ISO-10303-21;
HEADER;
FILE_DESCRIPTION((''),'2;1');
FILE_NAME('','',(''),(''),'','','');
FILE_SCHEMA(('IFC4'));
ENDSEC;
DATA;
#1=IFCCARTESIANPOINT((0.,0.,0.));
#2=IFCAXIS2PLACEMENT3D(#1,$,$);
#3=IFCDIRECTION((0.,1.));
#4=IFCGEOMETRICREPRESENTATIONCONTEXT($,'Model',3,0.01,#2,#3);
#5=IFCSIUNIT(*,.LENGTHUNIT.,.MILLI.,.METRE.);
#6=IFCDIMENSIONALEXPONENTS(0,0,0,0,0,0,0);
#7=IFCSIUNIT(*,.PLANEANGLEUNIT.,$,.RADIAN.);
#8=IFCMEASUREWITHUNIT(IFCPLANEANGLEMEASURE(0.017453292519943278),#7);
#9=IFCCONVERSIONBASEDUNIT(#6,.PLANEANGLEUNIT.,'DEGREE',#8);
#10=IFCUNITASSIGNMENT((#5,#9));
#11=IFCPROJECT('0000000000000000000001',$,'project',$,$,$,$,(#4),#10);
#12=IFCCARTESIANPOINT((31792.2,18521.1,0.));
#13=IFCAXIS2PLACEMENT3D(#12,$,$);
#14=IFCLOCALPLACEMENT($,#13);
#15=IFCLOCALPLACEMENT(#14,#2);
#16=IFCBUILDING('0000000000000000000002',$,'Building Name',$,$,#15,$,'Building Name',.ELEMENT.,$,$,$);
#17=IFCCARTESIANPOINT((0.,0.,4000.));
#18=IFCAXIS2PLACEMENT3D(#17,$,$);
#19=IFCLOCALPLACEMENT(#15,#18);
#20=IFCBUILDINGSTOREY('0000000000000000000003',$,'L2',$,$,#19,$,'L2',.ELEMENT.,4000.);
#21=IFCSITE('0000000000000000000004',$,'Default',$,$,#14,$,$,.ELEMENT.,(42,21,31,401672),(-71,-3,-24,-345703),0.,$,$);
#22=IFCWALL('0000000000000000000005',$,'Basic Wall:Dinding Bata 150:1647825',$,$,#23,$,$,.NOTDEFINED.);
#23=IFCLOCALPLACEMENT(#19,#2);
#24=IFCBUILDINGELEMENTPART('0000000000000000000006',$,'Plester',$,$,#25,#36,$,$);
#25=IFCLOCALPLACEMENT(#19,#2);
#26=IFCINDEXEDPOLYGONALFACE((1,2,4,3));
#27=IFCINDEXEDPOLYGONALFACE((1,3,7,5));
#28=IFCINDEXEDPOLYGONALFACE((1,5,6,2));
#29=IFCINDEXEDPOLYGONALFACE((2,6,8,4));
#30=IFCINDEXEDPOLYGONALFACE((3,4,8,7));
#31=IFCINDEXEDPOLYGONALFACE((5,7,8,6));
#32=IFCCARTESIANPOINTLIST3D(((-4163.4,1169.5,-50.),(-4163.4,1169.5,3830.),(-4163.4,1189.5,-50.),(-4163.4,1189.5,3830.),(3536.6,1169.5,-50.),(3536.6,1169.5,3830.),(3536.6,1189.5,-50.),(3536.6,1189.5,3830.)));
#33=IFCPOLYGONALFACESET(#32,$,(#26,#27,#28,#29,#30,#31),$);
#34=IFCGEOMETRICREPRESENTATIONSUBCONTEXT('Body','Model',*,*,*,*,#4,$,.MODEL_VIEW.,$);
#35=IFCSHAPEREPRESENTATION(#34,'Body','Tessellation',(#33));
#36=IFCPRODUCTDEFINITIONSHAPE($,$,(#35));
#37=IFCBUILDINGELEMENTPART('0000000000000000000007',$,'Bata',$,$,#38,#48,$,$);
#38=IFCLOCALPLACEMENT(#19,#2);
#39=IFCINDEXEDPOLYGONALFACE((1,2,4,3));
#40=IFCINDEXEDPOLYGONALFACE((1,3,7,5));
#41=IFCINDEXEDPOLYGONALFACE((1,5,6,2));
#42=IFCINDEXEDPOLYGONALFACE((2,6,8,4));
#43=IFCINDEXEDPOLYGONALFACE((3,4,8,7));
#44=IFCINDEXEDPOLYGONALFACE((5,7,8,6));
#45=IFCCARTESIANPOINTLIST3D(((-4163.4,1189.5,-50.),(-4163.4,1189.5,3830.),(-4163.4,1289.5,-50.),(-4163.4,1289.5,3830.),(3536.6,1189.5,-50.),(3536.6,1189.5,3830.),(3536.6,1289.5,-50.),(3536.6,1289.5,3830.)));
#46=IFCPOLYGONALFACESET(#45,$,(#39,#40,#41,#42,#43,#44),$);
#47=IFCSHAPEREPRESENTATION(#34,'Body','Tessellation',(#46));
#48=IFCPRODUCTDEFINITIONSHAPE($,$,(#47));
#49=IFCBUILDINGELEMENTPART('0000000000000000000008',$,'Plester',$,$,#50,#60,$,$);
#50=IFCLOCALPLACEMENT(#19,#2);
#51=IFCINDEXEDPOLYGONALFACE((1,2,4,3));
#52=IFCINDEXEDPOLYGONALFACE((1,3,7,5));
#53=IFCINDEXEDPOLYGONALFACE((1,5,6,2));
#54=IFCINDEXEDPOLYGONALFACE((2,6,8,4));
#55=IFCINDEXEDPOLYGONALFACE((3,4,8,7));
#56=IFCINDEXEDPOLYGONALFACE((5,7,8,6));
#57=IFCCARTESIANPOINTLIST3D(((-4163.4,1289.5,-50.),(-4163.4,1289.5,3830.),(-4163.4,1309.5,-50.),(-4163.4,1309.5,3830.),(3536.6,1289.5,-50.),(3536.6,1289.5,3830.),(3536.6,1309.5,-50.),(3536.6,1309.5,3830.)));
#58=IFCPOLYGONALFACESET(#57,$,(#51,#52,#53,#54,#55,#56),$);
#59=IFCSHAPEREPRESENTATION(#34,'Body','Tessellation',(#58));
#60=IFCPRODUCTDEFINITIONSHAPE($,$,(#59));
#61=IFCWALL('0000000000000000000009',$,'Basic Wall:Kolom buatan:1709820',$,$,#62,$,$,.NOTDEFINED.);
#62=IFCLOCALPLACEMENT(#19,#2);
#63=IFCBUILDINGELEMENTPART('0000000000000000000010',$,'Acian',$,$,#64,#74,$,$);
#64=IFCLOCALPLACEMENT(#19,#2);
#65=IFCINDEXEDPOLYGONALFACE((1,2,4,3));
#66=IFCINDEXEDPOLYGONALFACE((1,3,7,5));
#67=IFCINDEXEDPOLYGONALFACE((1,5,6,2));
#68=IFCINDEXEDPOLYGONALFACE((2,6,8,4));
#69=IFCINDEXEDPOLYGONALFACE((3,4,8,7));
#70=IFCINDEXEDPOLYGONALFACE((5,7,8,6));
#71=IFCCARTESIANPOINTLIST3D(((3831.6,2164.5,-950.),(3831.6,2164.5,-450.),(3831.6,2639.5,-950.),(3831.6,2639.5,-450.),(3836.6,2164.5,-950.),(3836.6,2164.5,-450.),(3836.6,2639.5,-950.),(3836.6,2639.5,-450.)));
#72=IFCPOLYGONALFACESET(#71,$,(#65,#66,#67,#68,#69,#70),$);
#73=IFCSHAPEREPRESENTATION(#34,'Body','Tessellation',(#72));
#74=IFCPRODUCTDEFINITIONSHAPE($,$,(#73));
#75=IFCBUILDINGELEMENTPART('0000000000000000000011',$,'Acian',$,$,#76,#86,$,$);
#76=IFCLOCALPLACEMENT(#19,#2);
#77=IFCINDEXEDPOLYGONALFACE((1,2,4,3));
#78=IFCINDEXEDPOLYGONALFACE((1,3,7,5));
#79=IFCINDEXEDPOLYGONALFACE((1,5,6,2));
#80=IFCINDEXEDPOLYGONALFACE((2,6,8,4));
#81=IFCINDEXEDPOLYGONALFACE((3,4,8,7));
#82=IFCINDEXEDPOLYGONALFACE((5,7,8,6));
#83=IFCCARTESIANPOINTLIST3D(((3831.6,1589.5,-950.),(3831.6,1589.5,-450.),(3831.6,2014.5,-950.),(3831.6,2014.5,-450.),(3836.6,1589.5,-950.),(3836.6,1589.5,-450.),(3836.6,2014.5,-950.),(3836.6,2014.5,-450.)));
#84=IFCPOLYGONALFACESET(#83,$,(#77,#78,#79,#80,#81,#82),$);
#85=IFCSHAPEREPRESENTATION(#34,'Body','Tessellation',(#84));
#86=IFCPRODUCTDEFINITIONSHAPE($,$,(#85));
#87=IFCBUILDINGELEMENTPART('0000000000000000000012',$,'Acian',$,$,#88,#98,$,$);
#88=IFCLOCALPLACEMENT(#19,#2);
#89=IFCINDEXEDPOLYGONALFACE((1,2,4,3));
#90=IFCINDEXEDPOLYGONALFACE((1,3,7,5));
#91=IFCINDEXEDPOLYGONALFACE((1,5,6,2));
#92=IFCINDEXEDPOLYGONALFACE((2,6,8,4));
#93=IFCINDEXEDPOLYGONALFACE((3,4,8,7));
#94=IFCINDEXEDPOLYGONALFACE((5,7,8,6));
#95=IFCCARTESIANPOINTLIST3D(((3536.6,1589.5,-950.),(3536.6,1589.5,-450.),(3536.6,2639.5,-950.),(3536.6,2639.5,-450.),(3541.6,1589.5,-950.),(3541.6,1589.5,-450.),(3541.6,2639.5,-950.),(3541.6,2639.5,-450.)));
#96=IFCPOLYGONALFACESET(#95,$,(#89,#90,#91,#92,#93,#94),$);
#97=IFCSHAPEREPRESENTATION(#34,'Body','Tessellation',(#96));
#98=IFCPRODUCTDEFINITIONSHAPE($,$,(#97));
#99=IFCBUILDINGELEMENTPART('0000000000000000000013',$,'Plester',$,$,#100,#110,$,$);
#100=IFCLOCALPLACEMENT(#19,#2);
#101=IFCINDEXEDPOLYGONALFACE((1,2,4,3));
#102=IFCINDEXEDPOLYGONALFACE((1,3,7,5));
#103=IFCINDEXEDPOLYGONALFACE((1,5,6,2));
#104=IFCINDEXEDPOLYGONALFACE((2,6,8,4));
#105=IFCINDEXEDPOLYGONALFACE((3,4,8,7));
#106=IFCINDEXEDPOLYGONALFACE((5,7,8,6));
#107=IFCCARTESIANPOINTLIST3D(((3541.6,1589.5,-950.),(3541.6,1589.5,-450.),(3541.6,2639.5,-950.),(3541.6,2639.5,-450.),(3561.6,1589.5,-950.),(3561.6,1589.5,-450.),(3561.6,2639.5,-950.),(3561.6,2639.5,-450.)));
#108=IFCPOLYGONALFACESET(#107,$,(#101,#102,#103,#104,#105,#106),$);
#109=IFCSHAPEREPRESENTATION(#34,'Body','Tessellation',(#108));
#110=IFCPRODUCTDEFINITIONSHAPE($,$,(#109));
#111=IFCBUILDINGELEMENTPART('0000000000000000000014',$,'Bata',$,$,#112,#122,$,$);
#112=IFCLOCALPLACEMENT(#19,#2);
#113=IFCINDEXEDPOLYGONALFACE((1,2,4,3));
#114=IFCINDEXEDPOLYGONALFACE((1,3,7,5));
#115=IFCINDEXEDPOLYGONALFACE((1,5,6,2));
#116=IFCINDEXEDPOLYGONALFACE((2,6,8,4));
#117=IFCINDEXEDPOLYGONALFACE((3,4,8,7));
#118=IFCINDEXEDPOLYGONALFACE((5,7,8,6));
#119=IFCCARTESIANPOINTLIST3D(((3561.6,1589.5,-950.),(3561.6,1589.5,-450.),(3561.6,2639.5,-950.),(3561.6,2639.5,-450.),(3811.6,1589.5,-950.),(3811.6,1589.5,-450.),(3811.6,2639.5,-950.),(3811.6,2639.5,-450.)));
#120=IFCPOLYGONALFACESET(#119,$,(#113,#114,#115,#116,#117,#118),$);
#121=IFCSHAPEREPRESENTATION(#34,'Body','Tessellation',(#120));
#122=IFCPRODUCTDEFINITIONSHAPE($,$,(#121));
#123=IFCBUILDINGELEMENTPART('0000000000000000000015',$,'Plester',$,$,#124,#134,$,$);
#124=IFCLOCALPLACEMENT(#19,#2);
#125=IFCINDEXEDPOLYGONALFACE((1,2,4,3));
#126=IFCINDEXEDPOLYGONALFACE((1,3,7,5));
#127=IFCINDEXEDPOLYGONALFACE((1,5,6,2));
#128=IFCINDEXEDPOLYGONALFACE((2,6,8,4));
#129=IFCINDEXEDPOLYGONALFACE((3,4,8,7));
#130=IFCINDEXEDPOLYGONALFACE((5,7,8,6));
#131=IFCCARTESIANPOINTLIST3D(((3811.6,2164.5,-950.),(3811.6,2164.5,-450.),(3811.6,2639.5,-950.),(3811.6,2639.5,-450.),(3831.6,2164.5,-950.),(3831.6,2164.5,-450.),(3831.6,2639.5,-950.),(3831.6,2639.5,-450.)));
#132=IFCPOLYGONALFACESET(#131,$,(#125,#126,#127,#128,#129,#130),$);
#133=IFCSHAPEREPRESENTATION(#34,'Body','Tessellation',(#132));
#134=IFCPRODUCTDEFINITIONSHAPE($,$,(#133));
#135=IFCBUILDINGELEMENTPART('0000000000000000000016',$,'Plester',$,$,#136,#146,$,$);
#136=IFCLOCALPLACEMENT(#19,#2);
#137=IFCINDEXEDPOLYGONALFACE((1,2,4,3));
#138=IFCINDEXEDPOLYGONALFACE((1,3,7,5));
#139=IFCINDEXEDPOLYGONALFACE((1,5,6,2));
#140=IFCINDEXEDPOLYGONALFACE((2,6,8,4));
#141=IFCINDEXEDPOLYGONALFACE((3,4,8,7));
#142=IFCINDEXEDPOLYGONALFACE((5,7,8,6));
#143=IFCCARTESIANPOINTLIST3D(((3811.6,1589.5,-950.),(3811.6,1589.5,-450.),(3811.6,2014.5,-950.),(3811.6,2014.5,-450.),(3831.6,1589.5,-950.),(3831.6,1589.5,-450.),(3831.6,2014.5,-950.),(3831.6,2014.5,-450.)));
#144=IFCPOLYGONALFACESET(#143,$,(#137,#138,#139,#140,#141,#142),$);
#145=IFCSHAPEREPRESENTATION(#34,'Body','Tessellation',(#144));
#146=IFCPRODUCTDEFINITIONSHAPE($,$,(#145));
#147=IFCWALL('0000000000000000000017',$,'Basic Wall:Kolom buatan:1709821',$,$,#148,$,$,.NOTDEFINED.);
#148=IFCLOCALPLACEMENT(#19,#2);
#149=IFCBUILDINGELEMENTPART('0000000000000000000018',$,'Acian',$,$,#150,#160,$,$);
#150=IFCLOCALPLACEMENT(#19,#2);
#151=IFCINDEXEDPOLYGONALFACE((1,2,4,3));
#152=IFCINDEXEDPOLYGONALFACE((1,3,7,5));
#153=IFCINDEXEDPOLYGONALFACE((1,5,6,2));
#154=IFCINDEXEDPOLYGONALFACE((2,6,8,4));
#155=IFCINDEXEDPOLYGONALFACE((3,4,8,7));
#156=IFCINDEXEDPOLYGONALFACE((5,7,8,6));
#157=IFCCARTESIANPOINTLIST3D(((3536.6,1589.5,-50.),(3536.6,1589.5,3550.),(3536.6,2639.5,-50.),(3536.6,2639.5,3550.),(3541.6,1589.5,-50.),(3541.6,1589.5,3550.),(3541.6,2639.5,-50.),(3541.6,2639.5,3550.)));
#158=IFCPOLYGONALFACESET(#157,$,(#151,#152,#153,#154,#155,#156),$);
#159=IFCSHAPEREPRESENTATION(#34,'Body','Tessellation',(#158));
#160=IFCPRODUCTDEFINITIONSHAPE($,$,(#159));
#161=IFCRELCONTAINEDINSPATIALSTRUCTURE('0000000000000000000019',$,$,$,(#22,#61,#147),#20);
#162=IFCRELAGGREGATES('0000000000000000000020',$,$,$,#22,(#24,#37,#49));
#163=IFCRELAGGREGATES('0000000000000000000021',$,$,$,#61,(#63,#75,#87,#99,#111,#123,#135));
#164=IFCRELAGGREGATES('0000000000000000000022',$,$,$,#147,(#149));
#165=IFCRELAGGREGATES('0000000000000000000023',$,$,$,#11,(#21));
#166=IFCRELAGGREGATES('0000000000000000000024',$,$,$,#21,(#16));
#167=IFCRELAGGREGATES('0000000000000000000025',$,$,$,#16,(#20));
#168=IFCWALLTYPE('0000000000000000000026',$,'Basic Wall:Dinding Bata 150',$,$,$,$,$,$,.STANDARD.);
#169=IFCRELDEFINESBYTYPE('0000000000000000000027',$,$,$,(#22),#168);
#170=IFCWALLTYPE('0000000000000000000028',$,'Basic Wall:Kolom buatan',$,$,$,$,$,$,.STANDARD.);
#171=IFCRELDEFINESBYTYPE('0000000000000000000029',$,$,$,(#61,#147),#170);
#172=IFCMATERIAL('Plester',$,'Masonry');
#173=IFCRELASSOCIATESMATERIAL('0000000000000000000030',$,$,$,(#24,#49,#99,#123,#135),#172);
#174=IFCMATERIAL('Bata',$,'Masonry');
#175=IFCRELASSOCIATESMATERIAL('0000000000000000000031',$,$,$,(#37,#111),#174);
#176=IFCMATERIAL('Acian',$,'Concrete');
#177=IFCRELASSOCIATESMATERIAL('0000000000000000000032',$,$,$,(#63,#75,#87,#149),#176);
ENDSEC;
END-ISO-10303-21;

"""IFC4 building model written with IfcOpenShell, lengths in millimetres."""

from ifc_helpers import new_model, entity, si_unit, converted_unit, direction, frame, origin, place, context, subcontext, project, spatial, indexed_curve, outline, extrude, material, type_object, element, aggregate, save


model = new_model("IFC4")

# Units and contexts
model_context = context("Model", 3, precision=0.01, world=origin(), true_north=direction((0.0, 1.0)))
body_context = subcontext(model_context, "Body", "Model", "MODEL_VIEW")
ifc_project = project(units=[si_unit("LENGTHUNIT", "METRE", prefix="MILLI"), converted_unit("PLANEANGLEUNIT", "DEGREE", entity("IfcPlaneAngleMeasure", 0.017453292519943278), si_unit("PLANEANGLEUNIT", "RADIAN"), dimensions=[0, 0, 0, 0, 0, 0, 0])], contexts=[model_context])

# Site, building, storey
site_placement = place(None, frame((31792.2, 18521.1, 0.0)))
site = spatial("IfcSite", under=ifc_project, at=site_placement, Name="Default", CompositionType="ELEMENT", RefLatitude=(42, 21, 31, 401672), RefLongitude=(-71, -3, -24, -345703), RefElevation=0.0)
building_placement = place(site_placement, origin())
building = spatial("IfcBuilding", under=site, at=building_placement, Name="Building Name", LongName="Building Name", CompositionType="ELEMENT")
storey_placement = place(building_placement, frame((0.0, 0.0, 4000.0)))
storey = spatial("IfcBuildingStorey", under=building, at=storey_placement, Name="L2", LongName="L2", CompositionType="ELEMENT", Elevation=4000.0)

# Walls, building element parts
wall_type_1 = type_object("IfcWallType", Name="Basic Wall:Dinding Bata 150", PredefinedType="STANDARD")
ifc_material_1 = material(Name="Acian", Category="Concrete")
ifc_material_2 = material(Name="Plester", Category="Masonry")
ifc_material_3 = material(Name="Bata", Category="Masonry")
wall_1_placement = place(storey_placement, frame((3536.6, 1239.5, -50.0), z_axis=(0.0, 0.0, 1.0), x_axis=(-1.0, 0.0, 0.0)))
wall_1 = element("IfcWall", 1, at=wall_1_placement, inside=storey, type_object=wall_type_1, Name="Basic Wall:Dinding Bata 150:1647825", PredefinedType="NOTDEFINED")
building_element_part_1_placement = place(wall_1_placement, origin())
building_element_part_1 = element("IfcBuildingElementPart", 2, at=building_element_part_1_placement, material=ifc_material_2, Name="Plester", context=body_context, shape_type="SweptSolid", body=[
    extrude(outline(indexed_curve([(-10.0, -3850.0), (10.0, -3850.0), (10.0, 3850.0), (-10.0, 3850.0), (-10.0, -3850.0)], self_intersect=False)), frame((3850.0, 60.0, 0.0), z_axis=(0.0, 0.0, 1.0), x_axis=(0.0, 1.0, 0.0)), (0.0, 0.0, 1.0), 3880.0),
])
building_element_part_2_placement = place(wall_1_placement, origin())
building_element_part_2 = element("IfcBuildingElementPart", 3, at=building_element_part_2_placement, material=ifc_material_3, Name="Bata", context=body_context, shape_type="SweptSolid", body=[
    extrude(outline(indexed_curve([(-50.0, -3850.0), (50.0, -3850.0), (50.0, 3850.0), (-50.0, 3850.0), (-50.0, -3850.0)], self_intersect=False)), frame((3850.0, 0.0, 0.0), z_axis=(0.0, 0.0, 1.0), x_axis=(0.0, 1.0, 0.0)), (0.0, 0.0, 1.0), 3880.0),
])
building_element_part_3_placement = place(wall_1_placement, origin())
building_element_part_3 = element("IfcBuildingElementPart", 4, at=building_element_part_3_placement, material=ifc_material_2, Name="Plester", context=body_context, shape_type="SweptSolid", body=[
    extrude(outline(indexed_curve([(-10.0, -3850.0), (10.0, -3850.0), (10.0, 3850.0), (-10.0, 3850.0), (-10.0, -3850.0)], self_intersect=False)), frame((3850.0, -60.0, 0.0), z_axis=(0.0, 0.0, 1.0), x_axis=(0.0, 1.0, 0.0)), (0.0, 0.0, 1.0), 3880.0),
])
aggregate(wall_1, [building_element_part_1, building_element_part_2, building_element_part_3])
wall_type_2 = type_object("IfcWallType", Name="Basic Wall:Kolom buatan", PredefinedType="STANDARD")
wall_2_placement = place(storey_placement, frame((3686.6, 1589.5, -950.0), z_axis=(0.0, 0.0, 1.0), x_axis=(0.0, 1.0, 0.0)))
wall_2 = element("IfcWall", 5, at=wall_2_placement, inside=storey, type_object=wall_type_2, Name="Basic Wall:Kolom buatan:1709820", PredefinedType="NOTDEFINED")
building_element_part_4_placement = place(wall_2_placement, origin())
building_element_part_4 = element("IfcBuildingElementPart", 6, at=building_element_part_4_placement, material=ifc_material_1, Name="Acian", context=body_context, shape_type="SweptSolid", body=[
    extrude(outline(indexed_curve([(-237.5, -2.5), (237.5, -2.5), (237.5, 2.5), (-237.5, 2.5), (-237.5, -2.5)], self_intersect=False)), frame((812.5, -147.5, 0.0), z_axis=(0.0, 0.0, 1.0), x_axis=(-1.0, 0.0, 0.0)), (0.0, 0.0, 1.0), 500.0),
])
building_element_part_5_placement = place(wall_2_placement, origin())
building_element_part_5 = element("IfcBuildingElementPart", 7, at=building_element_part_5_placement, material=ifc_material_1, Name="Acian", context=body_context, shape_type="SweptSolid", body=[
    extrude(outline(indexed_curve([(-212.5, -2.5), (212.5, -2.5), (212.5, 2.5), (-212.5, 2.5), (-212.5, -2.5)], self_intersect=False)), frame((212.5, -147.5, 0.0), z_axis=(0.0, 0.0, 1.0), x_axis=(-1.0, 0.0, 0.0)), (0.0, 0.0, 1.0), 500.0),
])
building_element_part_6_placement = place(wall_2_placement, origin())
building_element_part_6 = element("IfcBuildingElementPart", 8, at=building_element_part_6_placement, material=ifc_material_1, Name="Acian", context=body_context, shape_type="SweptSolid", body=[
    extrude(outline(indexed_curve([(-525.0, -2.5), (525.0, -2.5), (525.0, 2.5), (-525.0, 2.5), (-525.0, -2.5)], self_intersect=False)), frame((525.0, 147.5, 0.0), z_axis=(0.0, 0.0, 1.0), x_axis=(-1.0, 0.0, 0.0)), (0.0, 0.0, 1.0), 500.0),
])
building_element_part_7_placement = place(wall_2_placement, origin())
building_element_part_7 = element("IfcBuildingElementPart", 9, at=building_element_part_7_placement, material=ifc_material_2, Name="Plester", context=body_context, shape_type="SweptSolid", body=[
    extrude(outline(indexed_curve([(-525.0, -10.0), (525.0, -10.0), (525.0, 10.0), (-525.0, 10.0), (-525.0, -10.0)], self_intersect=False)), frame((525.0, 135.0, 0.0), z_axis=(0.0, 0.0, 1.0), x_axis=(-1.0, 0.0, 0.0)), (0.0, 0.0, 1.0), 500.0),
])
building_element_part_8_placement = place(wall_2_placement, origin())
building_element_part_8 = element("IfcBuildingElementPart", 10, at=building_element_part_8_placement, material=ifc_material_3, Name="Bata", context=body_context, shape_type="SweptSolid", body=[
    extrude(outline(indexed_curve([(-525.0, -125.0), (525.0, -125.0), (525.0, 125.0), (-525.0, 125.0), (-525.0, -125.0)], self_intersect=False)), frame((525.0, 0.0, 0.0), z_axis=(0.0, 0.0, 1.0), x_axis=(-1.0, 0.0, 0.0)), (0.0, 0.0, 1.0), 500.0),
])
building_element_part_9_placement = place(wall_2_placement, origin())
building_element_part_9 = element("IfcBuildingElementPart", 11, at=building_element_part_9_placement, material=ifc_material_2, Name="Plester", context=body_context, shape_type="SweptSolid", body=[
    extrude(outline(indexed_curve([(-237.5, -10.0), (237.5, -10.0), (237.5, 10.0), (-237.5, 10.0), (-237.5, -10.0)], self_intersect=False)), frame((812.5, -135.0, 0.0), z_axis=(0.0, 0.0, 1.0), x_axis=(-1.0, 0.0, 0.0)), (0.0, 0.0, 1.0), 500.0),
])
building_element_part_10_placement = place(wall_2_placement, origin())
building_element_part_10 = element("IfcBuildingElementPart", 12, at=building_element_part_10_placement, material=ifc_material_2, Name="Plester", context=body_context, shape_type="SweptSolid", body=[
    extrude(outline(indexed_curve([(-212.5, -10.0), (212.5, -10.0), (212.5, 10.0), (-212.5, 10.0), (-212.5, -10.0)], self_intersect=False)), frame((212.5, -135.0, 0.0), z_axis=(0.0, 0.0, 1.0), x_axis=(-1.0, 0.0, 0.0)), (0.0, 0.0, 1.0), 500.0),
])
aggregate(wall_2, [building_element_part_4, building_element_part_5, building_element_part_6, building_element_part_7, building_element_part_8, building_element_part_9, building_element_part_10])

# Wall, building element part
wall_3_placement = place(storey_placement, frame((3686.6, 1589.5, -50.0), z_axis=(0.0, 0.0, 1.0), x_axis=(0.0, 1.0, 0.0)))
wall_3 = element("IfcWall", 13, at=wall_3_placement, inside=storey, type_object=wall_type_2, Name="Basic Wall:Kolom buatan:1709821", PredefinedType="NOTDEFINED")
building_element_part_11_placement = place(wall_3_placement, origin())
building_element_part_11 = element("IfcBuildingElementPart", 14, at=building_element_part_11_placement, material=ifc_material_1, Name="Acian", context=body_context, shape_type="SweptSolid", body=[
    extrude(outline(indexed_curve([(-525.0, -2.5), (525.0, -2.5), (525.0, 2.5), (-525.0, 2.5), (-525.0, -2.5)], self_intersect=False)), frame((525.0, 147.5, 0.0), z_axis=(0.0, 0.0, 1.0), x_axis=(-1.0, 0.0, 0.0)), (0.0, 0.0, 1.0), 3600.0),
])
aggregate(wall_3, [building_element_part_11])

save(model, "model.ifc")
